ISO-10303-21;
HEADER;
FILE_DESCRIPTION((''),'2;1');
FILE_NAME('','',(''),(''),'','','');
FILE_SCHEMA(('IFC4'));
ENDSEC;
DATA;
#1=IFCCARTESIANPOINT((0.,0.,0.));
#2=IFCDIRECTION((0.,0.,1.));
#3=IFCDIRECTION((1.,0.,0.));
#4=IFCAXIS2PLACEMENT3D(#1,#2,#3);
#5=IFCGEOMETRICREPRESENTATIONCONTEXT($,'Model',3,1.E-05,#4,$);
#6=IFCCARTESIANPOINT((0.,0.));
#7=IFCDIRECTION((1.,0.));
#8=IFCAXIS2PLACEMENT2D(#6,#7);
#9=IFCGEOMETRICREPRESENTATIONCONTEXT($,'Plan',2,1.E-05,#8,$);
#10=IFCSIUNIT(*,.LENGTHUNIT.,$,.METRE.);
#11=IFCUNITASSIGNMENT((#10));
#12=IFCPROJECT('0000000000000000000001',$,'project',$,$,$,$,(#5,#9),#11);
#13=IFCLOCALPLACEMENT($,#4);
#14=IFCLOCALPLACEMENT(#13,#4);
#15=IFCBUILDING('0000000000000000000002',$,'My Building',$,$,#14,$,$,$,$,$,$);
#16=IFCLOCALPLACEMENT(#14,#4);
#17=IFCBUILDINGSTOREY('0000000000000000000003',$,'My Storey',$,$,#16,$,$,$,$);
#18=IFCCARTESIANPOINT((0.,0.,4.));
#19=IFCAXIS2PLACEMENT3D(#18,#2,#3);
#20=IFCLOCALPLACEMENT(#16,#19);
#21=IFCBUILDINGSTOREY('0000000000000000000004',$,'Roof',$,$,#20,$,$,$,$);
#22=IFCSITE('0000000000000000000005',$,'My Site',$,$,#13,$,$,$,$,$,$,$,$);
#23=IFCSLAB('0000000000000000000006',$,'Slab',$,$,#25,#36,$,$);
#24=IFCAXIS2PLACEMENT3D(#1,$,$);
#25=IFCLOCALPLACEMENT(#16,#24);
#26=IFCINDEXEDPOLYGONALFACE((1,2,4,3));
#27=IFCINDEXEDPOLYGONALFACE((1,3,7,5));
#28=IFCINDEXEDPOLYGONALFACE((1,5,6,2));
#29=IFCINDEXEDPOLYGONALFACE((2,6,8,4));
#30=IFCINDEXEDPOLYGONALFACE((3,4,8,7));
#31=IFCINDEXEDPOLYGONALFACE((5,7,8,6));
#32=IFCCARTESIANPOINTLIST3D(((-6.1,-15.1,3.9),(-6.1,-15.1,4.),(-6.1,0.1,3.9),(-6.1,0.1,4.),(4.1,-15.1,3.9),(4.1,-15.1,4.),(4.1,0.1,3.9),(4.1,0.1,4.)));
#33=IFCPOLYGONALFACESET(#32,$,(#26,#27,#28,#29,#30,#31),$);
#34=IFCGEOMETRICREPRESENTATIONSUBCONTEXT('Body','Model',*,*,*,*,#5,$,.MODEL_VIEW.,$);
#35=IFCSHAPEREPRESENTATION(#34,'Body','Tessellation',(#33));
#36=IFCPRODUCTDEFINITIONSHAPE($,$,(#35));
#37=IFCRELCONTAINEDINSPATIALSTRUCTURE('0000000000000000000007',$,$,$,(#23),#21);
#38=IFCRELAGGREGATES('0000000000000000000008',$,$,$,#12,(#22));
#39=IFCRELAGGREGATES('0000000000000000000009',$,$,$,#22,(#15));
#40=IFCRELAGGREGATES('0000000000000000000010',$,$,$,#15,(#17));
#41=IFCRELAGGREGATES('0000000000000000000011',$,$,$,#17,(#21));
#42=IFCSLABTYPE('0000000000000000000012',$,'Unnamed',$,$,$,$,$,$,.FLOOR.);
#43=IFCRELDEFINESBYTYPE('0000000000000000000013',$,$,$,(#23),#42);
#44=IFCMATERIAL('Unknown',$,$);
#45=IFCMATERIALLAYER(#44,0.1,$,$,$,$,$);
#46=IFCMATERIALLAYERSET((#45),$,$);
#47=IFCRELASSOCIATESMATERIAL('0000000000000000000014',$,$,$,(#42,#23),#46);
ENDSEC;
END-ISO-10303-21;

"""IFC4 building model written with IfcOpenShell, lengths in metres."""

from ifc_helpers import new_model, si_unit, frame, origin_with_axes, origin_2d_with_axis, place, context, subcontext, project, spatial, indexed_curve, outline, extrude, material, layer, layer_set, layer_usage, type_object, element, save


model = new_model("IFC4")

# Units and contexts
model_context = context("Model", 3, precision=1e-05, world=origin_with_axes())
plan_context = context("Plan", 2, precision=1e-05, world=origin_2d_with_axis())
body_context = subcontext(model_context, "Body", "Model", "MODEL_VIEW")
ifc_project = project(units=[si_unit("LENGTHUNIT", "METRE")], contexts=[model_context, plan_context])

# Site, building, storeys
site_placement = place(None, origin_with_axes())
site = spatial("IfcSite", under=ifc_project, at=site_placement, Name="My Site")
building_placement = place(site_placement, origin_with_axes())
building = spatial("IfcBuilding", under=site, at=building_placement, Name="My Building")
storey_1_placement = place(building_placement, origin_with_axes())
storey_1 = spatial("IfcBuildingStorey", under=building, at=storey_1_placement, Name="My Storey")
storey_2_placement = place(storey_1_placement, frame((0.0, 0.0, 4.0), z_axis=(0.0, 0.0, 1.0), x_axis=(1.0, 0.0, 0.0)))
storey_2 = spatial("IfcBuildingStorey", under=storey_1, at=storey_2_placement, Name="Roof")

# Slab
ifc_material = material(Name="Unknown")
ifc_layer = layer(ifc_material, 0.1)
ifc_layer_set = layer_set([ifc_layer])
ifc_layer_usage = layer_usage(ifc_layer_set, "AXIS3", "POSITIVE", -0.1)
slab_type = type_object("IfcSlabType", Name="Unnamed", PredefinedType="FLOOR", material=ifc_layer_set)
slab_placement = place(storey_2_placement, frame((-6.1, 0.1, 0.0), z_axis=(0.0, 0.0, 1.0), x_axis=(1.0, 0.0, 0.0)))
element("IfcSlab", 1, at=slab_placement, inside=storey_2, type_object=slab_type, material=ifc_layer_usage, Name="Slab", context=body_context, shape_type="SweptSolid", body=[
    extrude(outline(indexed_curve([(0.0, 0.0), (10.2, 0.0), (10.2, -15.2), (0.0, -15.2), (0.0, 0.0)])), frame((0.0, 0.0, -0.1), z_axis=(0.0, 0.0, 1.0), x_axis=(1.0, 0.0, 0.0)), (0.0, 0.0, 1.0), 0.1),
])

save(model, "model.ifc")
